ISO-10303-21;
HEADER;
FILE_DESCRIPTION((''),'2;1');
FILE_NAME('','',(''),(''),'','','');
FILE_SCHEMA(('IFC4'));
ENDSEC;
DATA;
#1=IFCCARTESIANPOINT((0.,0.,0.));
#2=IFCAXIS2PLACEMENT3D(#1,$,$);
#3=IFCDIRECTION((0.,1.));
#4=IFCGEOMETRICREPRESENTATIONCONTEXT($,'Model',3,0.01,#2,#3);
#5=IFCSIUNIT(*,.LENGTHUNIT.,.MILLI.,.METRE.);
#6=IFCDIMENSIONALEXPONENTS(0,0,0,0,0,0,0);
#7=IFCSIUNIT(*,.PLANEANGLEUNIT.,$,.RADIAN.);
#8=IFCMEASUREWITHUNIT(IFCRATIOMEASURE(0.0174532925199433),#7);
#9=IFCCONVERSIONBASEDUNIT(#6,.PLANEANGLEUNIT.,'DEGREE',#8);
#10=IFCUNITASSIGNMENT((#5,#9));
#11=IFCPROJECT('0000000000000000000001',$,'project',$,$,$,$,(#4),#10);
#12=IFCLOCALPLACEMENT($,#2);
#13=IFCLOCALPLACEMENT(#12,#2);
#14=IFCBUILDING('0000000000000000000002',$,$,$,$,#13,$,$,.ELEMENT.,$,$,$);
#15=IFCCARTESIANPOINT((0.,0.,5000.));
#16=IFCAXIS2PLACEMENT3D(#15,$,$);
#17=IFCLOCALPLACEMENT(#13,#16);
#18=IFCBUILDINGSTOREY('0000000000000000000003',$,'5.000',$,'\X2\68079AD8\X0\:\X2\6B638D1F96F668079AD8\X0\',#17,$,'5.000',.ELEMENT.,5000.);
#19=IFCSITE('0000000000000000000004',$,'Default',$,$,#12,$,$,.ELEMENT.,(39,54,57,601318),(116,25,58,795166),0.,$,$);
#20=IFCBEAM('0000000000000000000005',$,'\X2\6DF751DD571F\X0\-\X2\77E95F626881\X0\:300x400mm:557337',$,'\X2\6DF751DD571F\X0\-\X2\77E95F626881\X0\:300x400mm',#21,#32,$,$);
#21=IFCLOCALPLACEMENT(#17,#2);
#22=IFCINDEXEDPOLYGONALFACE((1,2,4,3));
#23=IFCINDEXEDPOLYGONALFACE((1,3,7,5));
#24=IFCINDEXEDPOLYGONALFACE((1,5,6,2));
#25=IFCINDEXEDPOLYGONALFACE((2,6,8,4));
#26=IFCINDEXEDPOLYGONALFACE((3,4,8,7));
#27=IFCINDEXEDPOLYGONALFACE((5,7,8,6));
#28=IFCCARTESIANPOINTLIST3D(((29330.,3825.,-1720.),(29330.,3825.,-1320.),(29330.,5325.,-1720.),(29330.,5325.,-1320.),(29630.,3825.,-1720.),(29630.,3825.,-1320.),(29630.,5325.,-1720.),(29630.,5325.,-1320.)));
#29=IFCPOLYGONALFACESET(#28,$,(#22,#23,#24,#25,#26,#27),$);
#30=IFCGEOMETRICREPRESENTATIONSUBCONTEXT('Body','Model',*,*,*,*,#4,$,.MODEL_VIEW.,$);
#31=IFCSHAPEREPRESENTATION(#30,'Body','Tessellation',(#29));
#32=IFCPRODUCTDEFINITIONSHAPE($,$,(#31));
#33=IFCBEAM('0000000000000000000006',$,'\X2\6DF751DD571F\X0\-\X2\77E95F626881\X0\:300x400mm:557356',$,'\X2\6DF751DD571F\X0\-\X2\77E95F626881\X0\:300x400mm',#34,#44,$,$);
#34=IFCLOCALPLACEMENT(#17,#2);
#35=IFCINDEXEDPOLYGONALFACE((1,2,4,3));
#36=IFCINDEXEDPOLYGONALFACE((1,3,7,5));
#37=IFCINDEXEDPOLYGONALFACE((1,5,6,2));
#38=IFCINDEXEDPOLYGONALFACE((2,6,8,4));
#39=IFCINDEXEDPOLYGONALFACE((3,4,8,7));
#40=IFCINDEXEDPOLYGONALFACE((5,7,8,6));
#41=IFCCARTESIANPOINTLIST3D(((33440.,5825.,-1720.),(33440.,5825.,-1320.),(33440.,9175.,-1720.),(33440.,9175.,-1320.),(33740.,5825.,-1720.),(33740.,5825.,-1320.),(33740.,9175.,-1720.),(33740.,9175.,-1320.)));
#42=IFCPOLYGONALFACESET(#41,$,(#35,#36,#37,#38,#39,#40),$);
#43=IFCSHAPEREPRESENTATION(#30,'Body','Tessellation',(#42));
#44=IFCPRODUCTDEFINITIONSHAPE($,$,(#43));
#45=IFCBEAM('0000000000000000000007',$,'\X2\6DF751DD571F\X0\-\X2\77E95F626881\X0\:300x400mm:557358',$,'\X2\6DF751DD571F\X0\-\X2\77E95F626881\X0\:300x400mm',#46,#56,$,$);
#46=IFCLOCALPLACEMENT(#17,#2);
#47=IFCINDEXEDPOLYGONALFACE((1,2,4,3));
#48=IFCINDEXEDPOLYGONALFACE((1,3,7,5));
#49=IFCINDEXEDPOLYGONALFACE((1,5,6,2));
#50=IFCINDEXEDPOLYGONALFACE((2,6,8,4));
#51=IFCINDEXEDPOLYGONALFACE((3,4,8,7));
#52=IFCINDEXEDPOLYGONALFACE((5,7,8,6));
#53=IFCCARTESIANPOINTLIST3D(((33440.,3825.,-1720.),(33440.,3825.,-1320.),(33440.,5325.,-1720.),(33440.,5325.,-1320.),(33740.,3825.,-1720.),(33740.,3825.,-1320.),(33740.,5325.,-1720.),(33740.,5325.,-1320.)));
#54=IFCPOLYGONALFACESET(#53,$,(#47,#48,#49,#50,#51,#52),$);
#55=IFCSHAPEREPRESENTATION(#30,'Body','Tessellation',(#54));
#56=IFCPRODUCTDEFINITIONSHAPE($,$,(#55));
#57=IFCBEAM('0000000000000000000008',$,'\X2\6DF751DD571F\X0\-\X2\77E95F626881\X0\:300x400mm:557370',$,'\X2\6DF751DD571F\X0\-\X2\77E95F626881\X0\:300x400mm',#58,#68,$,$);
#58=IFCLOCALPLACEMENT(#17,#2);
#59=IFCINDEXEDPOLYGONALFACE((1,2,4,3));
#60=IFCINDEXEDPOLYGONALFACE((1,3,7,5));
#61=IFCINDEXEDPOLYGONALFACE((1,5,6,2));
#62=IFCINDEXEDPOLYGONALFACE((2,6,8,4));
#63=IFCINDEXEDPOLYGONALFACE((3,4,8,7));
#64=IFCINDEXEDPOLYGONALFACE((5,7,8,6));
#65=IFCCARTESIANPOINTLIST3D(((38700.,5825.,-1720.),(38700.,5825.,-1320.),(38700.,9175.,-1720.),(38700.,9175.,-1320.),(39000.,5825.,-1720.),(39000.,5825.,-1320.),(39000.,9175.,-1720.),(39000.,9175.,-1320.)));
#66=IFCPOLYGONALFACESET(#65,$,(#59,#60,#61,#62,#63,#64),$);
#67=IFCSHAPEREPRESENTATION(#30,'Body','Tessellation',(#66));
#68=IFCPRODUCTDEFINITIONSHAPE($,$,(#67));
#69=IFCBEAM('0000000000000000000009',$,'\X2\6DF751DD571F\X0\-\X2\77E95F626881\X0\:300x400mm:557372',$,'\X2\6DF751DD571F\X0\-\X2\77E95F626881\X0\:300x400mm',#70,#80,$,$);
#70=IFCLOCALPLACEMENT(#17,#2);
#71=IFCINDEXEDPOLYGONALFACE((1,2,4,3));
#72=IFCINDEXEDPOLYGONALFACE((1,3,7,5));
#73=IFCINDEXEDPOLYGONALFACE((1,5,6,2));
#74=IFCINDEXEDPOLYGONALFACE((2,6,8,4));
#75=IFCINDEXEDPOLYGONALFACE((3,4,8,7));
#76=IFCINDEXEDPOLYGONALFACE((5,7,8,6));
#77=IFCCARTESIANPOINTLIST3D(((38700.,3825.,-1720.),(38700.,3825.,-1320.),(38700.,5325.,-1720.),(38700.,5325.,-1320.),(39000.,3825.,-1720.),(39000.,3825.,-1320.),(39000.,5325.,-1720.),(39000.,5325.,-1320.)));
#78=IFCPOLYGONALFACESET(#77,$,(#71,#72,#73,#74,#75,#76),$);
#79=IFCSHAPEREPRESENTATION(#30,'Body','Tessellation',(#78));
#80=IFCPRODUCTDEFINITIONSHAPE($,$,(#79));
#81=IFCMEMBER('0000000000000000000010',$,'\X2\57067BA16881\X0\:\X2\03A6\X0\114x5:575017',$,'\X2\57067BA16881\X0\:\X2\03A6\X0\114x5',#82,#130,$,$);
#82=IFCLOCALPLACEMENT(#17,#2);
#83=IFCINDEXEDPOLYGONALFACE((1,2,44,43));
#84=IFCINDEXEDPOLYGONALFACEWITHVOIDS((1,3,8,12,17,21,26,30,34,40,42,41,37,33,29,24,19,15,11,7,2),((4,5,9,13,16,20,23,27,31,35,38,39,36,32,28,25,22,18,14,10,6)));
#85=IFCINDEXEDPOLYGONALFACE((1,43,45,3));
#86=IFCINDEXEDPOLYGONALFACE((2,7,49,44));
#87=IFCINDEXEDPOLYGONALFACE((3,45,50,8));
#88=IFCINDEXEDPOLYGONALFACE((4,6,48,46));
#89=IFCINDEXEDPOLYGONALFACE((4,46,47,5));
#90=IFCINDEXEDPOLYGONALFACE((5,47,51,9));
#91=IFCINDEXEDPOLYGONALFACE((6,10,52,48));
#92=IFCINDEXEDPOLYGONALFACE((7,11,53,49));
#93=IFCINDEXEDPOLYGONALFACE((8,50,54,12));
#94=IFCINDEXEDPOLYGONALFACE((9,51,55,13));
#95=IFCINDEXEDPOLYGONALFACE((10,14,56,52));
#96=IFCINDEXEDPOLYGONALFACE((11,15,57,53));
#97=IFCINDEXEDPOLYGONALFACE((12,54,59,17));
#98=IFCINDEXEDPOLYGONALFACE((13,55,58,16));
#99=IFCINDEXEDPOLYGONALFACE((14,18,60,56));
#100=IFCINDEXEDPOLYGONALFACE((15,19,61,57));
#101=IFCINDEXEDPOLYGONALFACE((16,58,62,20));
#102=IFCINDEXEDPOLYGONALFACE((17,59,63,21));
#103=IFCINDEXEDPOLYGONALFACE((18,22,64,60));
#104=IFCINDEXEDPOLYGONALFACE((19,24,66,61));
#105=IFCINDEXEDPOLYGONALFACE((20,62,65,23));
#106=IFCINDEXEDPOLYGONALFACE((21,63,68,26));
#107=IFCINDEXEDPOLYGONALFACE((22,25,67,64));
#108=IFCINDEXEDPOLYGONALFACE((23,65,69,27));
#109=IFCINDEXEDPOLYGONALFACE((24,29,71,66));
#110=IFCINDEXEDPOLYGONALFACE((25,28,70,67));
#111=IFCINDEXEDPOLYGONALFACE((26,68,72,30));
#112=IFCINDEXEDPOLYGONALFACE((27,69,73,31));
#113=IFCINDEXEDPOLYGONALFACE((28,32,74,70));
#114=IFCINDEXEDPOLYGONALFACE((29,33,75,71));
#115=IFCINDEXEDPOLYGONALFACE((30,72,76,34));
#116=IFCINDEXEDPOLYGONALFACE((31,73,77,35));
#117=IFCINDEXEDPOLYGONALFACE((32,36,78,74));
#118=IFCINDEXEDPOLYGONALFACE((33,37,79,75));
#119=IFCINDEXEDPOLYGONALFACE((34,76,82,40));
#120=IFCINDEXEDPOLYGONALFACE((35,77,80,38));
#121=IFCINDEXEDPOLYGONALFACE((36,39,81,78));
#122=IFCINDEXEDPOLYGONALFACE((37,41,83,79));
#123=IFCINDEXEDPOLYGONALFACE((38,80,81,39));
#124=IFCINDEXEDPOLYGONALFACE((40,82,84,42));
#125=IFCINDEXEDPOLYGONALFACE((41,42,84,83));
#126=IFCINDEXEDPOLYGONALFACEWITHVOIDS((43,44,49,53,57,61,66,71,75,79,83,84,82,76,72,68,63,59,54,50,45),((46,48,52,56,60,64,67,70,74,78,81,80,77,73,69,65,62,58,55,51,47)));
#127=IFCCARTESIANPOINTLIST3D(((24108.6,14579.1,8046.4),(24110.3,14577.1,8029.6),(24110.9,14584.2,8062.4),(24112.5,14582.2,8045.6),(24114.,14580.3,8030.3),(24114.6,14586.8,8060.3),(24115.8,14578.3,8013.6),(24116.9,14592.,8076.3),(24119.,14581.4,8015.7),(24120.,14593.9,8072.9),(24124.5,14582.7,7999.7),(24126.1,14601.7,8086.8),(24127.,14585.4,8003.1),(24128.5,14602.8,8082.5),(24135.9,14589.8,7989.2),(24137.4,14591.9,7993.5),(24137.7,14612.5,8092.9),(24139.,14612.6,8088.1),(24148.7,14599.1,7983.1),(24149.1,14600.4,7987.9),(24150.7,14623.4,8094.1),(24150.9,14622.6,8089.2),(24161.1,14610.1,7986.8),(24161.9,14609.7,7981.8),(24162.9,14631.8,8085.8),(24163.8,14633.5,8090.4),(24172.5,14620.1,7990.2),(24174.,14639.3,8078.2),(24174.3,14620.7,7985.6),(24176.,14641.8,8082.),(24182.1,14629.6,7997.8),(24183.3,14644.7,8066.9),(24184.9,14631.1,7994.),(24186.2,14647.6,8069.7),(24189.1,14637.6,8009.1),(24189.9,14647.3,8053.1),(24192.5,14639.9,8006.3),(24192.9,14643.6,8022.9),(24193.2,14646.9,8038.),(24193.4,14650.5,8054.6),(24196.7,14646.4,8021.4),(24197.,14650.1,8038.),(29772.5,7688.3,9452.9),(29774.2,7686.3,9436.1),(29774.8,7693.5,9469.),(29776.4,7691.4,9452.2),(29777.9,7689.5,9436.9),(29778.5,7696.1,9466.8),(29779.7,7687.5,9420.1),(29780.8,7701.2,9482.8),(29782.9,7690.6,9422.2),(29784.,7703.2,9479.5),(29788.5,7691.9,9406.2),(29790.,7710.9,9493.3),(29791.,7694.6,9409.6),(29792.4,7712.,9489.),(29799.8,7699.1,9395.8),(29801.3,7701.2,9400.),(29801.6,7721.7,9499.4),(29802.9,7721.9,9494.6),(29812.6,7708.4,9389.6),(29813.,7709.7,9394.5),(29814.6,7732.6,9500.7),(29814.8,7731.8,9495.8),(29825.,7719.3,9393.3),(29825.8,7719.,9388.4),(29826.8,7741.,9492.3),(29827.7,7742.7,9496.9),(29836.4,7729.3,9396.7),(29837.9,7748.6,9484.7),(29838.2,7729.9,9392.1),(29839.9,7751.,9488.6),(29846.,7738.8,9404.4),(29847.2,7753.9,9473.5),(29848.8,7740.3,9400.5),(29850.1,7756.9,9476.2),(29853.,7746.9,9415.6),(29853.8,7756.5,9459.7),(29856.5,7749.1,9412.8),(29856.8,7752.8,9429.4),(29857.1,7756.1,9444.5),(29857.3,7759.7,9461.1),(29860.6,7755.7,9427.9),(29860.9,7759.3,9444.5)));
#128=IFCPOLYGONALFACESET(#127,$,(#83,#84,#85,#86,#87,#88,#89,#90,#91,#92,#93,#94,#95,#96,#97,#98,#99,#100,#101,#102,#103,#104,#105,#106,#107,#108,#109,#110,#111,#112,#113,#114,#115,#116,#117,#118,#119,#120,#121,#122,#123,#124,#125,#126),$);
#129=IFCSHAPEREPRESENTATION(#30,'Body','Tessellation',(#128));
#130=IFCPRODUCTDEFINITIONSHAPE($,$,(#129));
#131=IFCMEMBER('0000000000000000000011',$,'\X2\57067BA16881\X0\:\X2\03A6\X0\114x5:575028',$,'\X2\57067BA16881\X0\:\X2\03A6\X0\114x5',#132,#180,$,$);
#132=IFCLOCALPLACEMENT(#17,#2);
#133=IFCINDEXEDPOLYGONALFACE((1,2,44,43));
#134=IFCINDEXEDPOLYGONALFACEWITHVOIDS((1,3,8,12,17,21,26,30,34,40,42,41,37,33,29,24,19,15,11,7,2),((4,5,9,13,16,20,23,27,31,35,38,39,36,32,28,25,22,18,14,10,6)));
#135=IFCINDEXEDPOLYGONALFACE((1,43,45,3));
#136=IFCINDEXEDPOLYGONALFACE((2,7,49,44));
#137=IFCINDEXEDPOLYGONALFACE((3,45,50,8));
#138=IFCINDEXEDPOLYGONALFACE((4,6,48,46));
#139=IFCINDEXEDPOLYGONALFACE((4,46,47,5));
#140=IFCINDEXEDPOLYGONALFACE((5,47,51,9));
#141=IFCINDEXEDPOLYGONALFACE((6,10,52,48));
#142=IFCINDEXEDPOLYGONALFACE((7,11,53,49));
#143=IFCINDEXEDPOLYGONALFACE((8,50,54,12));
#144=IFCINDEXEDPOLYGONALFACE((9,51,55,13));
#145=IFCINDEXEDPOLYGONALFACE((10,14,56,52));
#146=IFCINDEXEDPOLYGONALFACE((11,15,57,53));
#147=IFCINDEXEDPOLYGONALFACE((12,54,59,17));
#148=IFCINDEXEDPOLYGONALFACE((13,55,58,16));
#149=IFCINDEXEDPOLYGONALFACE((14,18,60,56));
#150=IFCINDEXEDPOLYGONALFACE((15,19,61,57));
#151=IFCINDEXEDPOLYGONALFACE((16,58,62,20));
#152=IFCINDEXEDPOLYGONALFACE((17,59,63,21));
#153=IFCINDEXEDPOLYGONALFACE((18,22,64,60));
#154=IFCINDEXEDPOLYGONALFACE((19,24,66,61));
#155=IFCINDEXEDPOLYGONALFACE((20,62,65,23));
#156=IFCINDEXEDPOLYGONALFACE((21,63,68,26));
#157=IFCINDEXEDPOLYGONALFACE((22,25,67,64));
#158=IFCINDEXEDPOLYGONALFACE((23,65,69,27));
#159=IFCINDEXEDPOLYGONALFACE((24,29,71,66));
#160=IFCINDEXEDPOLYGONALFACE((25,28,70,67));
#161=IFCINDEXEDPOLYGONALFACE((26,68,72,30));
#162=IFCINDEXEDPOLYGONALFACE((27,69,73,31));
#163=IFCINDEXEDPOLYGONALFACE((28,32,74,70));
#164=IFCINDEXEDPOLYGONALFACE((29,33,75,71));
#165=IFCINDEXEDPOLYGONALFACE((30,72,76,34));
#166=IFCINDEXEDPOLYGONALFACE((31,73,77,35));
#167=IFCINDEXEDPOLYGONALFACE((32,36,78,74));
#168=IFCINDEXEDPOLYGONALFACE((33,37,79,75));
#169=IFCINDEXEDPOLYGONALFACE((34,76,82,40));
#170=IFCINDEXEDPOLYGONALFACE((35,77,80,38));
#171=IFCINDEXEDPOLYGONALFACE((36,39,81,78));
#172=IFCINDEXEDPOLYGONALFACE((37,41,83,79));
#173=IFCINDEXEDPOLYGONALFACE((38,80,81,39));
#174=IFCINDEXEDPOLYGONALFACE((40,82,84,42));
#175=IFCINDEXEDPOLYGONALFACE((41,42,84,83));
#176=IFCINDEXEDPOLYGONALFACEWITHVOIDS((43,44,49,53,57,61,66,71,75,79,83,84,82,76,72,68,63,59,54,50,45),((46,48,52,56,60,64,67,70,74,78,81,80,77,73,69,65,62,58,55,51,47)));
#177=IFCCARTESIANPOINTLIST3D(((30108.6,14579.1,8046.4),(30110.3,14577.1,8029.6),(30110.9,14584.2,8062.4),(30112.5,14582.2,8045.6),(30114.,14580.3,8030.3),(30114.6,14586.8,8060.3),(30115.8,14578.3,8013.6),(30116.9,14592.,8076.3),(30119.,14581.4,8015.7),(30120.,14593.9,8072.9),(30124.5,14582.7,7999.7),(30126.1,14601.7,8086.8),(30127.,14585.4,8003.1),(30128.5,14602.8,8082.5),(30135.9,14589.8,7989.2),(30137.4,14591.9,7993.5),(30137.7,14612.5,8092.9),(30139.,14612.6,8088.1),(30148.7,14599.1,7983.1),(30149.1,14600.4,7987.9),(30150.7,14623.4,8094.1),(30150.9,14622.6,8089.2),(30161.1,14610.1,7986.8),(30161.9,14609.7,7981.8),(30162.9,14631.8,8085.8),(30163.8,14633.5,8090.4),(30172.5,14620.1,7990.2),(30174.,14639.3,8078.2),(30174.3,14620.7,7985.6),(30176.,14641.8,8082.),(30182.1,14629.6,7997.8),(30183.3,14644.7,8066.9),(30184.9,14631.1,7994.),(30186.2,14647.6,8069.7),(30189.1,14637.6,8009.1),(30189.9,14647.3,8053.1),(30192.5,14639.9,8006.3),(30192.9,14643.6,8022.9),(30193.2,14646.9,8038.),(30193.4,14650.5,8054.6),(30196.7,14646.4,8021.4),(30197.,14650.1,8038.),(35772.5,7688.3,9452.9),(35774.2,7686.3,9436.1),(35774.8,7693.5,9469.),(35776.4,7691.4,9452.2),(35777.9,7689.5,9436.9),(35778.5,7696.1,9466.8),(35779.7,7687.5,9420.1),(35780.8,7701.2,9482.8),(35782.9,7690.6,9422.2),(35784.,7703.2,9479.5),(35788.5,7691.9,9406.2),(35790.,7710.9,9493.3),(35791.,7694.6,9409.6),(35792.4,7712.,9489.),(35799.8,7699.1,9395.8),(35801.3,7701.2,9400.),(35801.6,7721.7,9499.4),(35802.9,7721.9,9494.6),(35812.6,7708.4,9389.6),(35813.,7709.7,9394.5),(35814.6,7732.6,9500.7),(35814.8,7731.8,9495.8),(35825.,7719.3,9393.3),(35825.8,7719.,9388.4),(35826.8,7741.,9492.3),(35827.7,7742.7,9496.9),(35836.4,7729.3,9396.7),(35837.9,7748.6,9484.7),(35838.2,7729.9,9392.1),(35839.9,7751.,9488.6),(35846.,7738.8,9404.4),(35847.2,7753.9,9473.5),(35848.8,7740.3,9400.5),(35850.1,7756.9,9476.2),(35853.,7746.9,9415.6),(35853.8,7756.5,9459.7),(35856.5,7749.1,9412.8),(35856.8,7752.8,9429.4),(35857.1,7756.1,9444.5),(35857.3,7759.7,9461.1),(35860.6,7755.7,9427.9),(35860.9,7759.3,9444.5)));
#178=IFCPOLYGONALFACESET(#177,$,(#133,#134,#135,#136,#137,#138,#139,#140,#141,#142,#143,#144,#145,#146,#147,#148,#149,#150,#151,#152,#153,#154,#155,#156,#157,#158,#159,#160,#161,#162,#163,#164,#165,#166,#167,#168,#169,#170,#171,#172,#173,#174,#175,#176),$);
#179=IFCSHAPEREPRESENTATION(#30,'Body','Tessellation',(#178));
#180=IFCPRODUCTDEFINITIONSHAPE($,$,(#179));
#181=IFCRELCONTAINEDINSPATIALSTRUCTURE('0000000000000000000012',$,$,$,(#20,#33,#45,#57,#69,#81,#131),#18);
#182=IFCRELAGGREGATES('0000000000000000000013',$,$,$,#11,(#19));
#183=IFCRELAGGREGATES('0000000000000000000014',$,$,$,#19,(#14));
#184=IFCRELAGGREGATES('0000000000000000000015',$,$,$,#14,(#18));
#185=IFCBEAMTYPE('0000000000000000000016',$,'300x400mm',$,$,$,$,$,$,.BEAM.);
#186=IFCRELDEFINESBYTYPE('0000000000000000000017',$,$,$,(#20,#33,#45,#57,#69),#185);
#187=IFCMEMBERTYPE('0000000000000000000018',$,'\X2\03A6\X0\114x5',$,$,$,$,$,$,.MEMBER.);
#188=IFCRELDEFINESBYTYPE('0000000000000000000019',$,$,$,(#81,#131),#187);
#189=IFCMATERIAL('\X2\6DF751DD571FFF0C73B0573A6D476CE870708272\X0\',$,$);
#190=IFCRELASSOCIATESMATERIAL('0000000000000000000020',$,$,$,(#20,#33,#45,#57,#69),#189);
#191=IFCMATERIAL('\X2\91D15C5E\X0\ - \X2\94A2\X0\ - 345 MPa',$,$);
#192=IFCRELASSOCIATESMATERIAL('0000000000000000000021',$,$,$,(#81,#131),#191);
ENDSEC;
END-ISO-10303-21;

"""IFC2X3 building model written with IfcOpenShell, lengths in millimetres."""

from ifc_helpers import new_model, entity, si_unit, converted_unit, direction, frame, frame_2d, origin, place, context, subcontext, project, spatial, rectangle, hollow_circle, extrude, source, transform, mapped, material, type_object, type_shapes, element, save


model = new_model("IFC2X3")

# Units and contexts
model_context = context("Model", 3, precision=0.01, world=origin(), true_north=direction((0.0, 1.0)))
body_context = subcontext(model_context, "Body", "Model", "MODEL_VIEW")
ifc_project = project(units=[si_unit("LENGTHUNIT", "METRE", prefix="MILLI"), converted_unit("PLANEANGLEUNIT", "DEGREE", entity("IfcRatioMeasure", 0.0174532925199433), si_unit("PLANEANGLEUNIT", "RADIAN"), dimensions=[0, 0, 0, 0, 0, 0, 0])], contexts=[model_context])

# Site, building, storey
site_placement = place(None, origin())
site = spatial("IfcSite", under=ifc_project, at=site_placement, Name="Default", CompositionType="ELEMENT", RefLatitude=(39, 54, 57, 601318), RefLongitude=(116, 25, 58, 795166), RefElevation=0.0)
building_placement = place(site_placement, origin())
building = spatial("IfcBuilding", under=site, at=building_placement, CompositionType="ELEMENT")
storey_placement = place(building_placement, frame((0.0, 0.0, 5000.0)))
storey = spatial("IfcBuildingStorey", under=building, at=storey_placement, Name="5.000", ObjectType="标高:正负零标高", LongName="5.000", CompositionType="ELEMENT", Elevation=5000.0)

# Beams
ifc_material_1 = material(Name="混凝土，现场浇注灰色")
beam_type_1 = type_object("IfcBeamType", Name="300x400mm", PredefinedType="BEAM")
beam_1_placement = place(storey_placement, frame((29480.0, 5325.0, -1320.0), z_axis=(0.0, 0.0, 1.0), x_axis=(0.0, -1.0, 0.0)))
element("IfcBeam", 1, at=beam_1_placement, inside=storey, type_object=beam_type_1, material=ifc_material_1, Name="混凝土-矩形梁:300x400mm:557337", ObjectType="混凝土-矩形梁:300x400mm", context=body_context, shape_type="SweptSolid", body=[
    extrude(rectangle(XDim=400.0, YDim=300.0, at=frame_2d((0.0, 0.0), x_axis=(1.0, 0.0))), frame((0.0, 0.0, -200.0), z_axis=(1.0, 0.0, 0.0), x_axis=(0.0, 0.0, -1.0)), (0.0, 0.0, 1.0), 1500.0),
])
beam_2_placement = place(storey_placement, frame((33590.0, 9175.0, -1320.0), z_axis=(0.0, 0.0, 1.0), x_axis=(0.0, -1.0, 0.0)))
element("IfcBeam", 2, at=beam_2_placement, inside=storey, type_object=beam_type_1, material=ifc_material_1, Name="混凝土-矩形梁:300x400mm:557356", ObjectType="混凝土-矩形梁:300x400mm", context=body_context, shape_type="SweptSolid", body=[
    extrude(rectangle(XDim=400.0, YDim=300.0, at=frame_2d((0.0, 0.0), x_axis=(1.0, 0.0))), frame((0.0, 0.0, -200.0), z_axis=(1.0, 0.0, 0.0), x_axis=(0.0, 0.0, -1.0)), (0.0, 0.0, 1.0), 3350.0),
])
beam_3_placement = place(storey_placement, frame((33590.0, 5325.0, -1320.0), z_axis=(0.0, 0.0, 1.0), x_axis=(0.0, -1.0, 0.0)))
element("IfcBeam", 3, at=beam_3_placement, inside=storey, type_object=beam_type_1, material=ifc_material_1, Name="混凝土-矩形梁:300x400mm:557358", ObjectType="混凝土-矩形梁:300x400mm", context=body_context, shape_type="SweptSolid", body=[
    extrude(rectangle(XDim=400.0, YDim=300.0, at=frame_2d((0.0, 0.0), x_axis=(1.0, 0.0))), frame((0.0, 0.0, -200.0), z_axis=(1.0, 0.0, 0.0), x_axis=(0.0, 0.0, -1.0)), (0.0, 0.0, 1.0), 1500.0),
])
beam_4_placement = place(storey_placement, frame((38850.0, 9175.0, -1320.0), z_axis=(0.0, 0.0, 1.0), x_axis=(0.0, -1.0, 0.0)))
element("IfcBeam", 4, at=beam_4_placement, inside=storey, type_object=beam_type_1, material=ifc_material_1, Name="混凝土-矩形梁:300x400mm:557370", ObjectType="混凝土-矩形梁:300x400mm", context=body_context, shape_type="SweptSolid", body=[
    extrude(rectangle(XDim=400.0, YDim=300.0, at=frame_2d((0.0, 0.0), x_axis=(1.0, 0.0))), frame((0.0, 0.0, -200.0), z_axis=(1.0, 0.0, 0.0), x_axis=(0.0, 0.0, -1.0)), (0.0, 0.0, 1.0), 3350.0),
])
beam_5_placement = place(storey_placement, frame((38850.0, 5325.0, -1320.0), z_axis=(0.0, 0.0, 1.0), x_axis=(0.0, -1.0, 0.0)))
element("IfcBeam", 5, at=beam_5_placement, inside=storey, type_object=beam_type_1, material=ifc_material_1, Name="混凝土-矩形梁:300x400mm:557372", ObjectType="混凝土-矩形梁:300x400mm", context=body_context, shape_type="SweptSolid", body=[
    extrude(rectangle(XDim=400.0, YDim=300.0, at=frame_2d((0.0, 0.0), x_axis=(1.0, 0.0))), frame((0.0, 0.0, -200.0), z_axis=(1.0, 0.0, 0.0), x_axis=(0.0, 0.0, -1.0)), (0.0, 0.0, 1.0), 1500.0),
])

# Members
ifc_material_2 = material(Name="金属 - 钢 - 345 MPa")
member_type_1 = type_object("IfcMemberType", Name="Φ114x5", PredefinedType="MEMBER")
shared_shape_1 = source(origin(), body_context, "Body", "SweptSolid", [
    extrude(hollow_circle(Radius=57.0, WallThickness=5.0, at=frame_2d((0.0, 0.0), x_axis=(1.0, 0.0))), frame((-4539.0, 0.0, 0.0), z_axis=(1.0, 0.0, 0.0), x_axis=(0.0, 1.0, 0.0)), (0.0, 0.0, 1.0), 9030.0),
])
type_shapes(member_type_1, [shared_shape_1])
for number, where, z_axis, x_axis, name in (
    (6, (27000.0, 11150.2, 8745.0), (-0.098907, 0.120331, 0.987794), (0.627233, -0.763097, 0.155763), "圆管梁:Φ114x5:575017"),
    (7, (33000.0, 11150.2, 8745.0), (-0.098907, 0.120331, 0.987794), (0.627233, -0.763097, 0.155763), "圆管梁:Φ114x5:575028"),
):
    element("IfcMember", number, at=place(storey_placement, frame(where, z_axis=z_axis, x_axis=x_axis)), inside=storey, type_object=member_type_1, material=ifc_material_2, Name=name, ObjectType="圆管梁:Φ114x5", context=body_context, shape_type="MappedRepresentation", body=[
        mapped(shared_shape_1, transform((0.0, 0.0, 0.0), scale=1.0)),
    ])

save(model, "model.ifc")
